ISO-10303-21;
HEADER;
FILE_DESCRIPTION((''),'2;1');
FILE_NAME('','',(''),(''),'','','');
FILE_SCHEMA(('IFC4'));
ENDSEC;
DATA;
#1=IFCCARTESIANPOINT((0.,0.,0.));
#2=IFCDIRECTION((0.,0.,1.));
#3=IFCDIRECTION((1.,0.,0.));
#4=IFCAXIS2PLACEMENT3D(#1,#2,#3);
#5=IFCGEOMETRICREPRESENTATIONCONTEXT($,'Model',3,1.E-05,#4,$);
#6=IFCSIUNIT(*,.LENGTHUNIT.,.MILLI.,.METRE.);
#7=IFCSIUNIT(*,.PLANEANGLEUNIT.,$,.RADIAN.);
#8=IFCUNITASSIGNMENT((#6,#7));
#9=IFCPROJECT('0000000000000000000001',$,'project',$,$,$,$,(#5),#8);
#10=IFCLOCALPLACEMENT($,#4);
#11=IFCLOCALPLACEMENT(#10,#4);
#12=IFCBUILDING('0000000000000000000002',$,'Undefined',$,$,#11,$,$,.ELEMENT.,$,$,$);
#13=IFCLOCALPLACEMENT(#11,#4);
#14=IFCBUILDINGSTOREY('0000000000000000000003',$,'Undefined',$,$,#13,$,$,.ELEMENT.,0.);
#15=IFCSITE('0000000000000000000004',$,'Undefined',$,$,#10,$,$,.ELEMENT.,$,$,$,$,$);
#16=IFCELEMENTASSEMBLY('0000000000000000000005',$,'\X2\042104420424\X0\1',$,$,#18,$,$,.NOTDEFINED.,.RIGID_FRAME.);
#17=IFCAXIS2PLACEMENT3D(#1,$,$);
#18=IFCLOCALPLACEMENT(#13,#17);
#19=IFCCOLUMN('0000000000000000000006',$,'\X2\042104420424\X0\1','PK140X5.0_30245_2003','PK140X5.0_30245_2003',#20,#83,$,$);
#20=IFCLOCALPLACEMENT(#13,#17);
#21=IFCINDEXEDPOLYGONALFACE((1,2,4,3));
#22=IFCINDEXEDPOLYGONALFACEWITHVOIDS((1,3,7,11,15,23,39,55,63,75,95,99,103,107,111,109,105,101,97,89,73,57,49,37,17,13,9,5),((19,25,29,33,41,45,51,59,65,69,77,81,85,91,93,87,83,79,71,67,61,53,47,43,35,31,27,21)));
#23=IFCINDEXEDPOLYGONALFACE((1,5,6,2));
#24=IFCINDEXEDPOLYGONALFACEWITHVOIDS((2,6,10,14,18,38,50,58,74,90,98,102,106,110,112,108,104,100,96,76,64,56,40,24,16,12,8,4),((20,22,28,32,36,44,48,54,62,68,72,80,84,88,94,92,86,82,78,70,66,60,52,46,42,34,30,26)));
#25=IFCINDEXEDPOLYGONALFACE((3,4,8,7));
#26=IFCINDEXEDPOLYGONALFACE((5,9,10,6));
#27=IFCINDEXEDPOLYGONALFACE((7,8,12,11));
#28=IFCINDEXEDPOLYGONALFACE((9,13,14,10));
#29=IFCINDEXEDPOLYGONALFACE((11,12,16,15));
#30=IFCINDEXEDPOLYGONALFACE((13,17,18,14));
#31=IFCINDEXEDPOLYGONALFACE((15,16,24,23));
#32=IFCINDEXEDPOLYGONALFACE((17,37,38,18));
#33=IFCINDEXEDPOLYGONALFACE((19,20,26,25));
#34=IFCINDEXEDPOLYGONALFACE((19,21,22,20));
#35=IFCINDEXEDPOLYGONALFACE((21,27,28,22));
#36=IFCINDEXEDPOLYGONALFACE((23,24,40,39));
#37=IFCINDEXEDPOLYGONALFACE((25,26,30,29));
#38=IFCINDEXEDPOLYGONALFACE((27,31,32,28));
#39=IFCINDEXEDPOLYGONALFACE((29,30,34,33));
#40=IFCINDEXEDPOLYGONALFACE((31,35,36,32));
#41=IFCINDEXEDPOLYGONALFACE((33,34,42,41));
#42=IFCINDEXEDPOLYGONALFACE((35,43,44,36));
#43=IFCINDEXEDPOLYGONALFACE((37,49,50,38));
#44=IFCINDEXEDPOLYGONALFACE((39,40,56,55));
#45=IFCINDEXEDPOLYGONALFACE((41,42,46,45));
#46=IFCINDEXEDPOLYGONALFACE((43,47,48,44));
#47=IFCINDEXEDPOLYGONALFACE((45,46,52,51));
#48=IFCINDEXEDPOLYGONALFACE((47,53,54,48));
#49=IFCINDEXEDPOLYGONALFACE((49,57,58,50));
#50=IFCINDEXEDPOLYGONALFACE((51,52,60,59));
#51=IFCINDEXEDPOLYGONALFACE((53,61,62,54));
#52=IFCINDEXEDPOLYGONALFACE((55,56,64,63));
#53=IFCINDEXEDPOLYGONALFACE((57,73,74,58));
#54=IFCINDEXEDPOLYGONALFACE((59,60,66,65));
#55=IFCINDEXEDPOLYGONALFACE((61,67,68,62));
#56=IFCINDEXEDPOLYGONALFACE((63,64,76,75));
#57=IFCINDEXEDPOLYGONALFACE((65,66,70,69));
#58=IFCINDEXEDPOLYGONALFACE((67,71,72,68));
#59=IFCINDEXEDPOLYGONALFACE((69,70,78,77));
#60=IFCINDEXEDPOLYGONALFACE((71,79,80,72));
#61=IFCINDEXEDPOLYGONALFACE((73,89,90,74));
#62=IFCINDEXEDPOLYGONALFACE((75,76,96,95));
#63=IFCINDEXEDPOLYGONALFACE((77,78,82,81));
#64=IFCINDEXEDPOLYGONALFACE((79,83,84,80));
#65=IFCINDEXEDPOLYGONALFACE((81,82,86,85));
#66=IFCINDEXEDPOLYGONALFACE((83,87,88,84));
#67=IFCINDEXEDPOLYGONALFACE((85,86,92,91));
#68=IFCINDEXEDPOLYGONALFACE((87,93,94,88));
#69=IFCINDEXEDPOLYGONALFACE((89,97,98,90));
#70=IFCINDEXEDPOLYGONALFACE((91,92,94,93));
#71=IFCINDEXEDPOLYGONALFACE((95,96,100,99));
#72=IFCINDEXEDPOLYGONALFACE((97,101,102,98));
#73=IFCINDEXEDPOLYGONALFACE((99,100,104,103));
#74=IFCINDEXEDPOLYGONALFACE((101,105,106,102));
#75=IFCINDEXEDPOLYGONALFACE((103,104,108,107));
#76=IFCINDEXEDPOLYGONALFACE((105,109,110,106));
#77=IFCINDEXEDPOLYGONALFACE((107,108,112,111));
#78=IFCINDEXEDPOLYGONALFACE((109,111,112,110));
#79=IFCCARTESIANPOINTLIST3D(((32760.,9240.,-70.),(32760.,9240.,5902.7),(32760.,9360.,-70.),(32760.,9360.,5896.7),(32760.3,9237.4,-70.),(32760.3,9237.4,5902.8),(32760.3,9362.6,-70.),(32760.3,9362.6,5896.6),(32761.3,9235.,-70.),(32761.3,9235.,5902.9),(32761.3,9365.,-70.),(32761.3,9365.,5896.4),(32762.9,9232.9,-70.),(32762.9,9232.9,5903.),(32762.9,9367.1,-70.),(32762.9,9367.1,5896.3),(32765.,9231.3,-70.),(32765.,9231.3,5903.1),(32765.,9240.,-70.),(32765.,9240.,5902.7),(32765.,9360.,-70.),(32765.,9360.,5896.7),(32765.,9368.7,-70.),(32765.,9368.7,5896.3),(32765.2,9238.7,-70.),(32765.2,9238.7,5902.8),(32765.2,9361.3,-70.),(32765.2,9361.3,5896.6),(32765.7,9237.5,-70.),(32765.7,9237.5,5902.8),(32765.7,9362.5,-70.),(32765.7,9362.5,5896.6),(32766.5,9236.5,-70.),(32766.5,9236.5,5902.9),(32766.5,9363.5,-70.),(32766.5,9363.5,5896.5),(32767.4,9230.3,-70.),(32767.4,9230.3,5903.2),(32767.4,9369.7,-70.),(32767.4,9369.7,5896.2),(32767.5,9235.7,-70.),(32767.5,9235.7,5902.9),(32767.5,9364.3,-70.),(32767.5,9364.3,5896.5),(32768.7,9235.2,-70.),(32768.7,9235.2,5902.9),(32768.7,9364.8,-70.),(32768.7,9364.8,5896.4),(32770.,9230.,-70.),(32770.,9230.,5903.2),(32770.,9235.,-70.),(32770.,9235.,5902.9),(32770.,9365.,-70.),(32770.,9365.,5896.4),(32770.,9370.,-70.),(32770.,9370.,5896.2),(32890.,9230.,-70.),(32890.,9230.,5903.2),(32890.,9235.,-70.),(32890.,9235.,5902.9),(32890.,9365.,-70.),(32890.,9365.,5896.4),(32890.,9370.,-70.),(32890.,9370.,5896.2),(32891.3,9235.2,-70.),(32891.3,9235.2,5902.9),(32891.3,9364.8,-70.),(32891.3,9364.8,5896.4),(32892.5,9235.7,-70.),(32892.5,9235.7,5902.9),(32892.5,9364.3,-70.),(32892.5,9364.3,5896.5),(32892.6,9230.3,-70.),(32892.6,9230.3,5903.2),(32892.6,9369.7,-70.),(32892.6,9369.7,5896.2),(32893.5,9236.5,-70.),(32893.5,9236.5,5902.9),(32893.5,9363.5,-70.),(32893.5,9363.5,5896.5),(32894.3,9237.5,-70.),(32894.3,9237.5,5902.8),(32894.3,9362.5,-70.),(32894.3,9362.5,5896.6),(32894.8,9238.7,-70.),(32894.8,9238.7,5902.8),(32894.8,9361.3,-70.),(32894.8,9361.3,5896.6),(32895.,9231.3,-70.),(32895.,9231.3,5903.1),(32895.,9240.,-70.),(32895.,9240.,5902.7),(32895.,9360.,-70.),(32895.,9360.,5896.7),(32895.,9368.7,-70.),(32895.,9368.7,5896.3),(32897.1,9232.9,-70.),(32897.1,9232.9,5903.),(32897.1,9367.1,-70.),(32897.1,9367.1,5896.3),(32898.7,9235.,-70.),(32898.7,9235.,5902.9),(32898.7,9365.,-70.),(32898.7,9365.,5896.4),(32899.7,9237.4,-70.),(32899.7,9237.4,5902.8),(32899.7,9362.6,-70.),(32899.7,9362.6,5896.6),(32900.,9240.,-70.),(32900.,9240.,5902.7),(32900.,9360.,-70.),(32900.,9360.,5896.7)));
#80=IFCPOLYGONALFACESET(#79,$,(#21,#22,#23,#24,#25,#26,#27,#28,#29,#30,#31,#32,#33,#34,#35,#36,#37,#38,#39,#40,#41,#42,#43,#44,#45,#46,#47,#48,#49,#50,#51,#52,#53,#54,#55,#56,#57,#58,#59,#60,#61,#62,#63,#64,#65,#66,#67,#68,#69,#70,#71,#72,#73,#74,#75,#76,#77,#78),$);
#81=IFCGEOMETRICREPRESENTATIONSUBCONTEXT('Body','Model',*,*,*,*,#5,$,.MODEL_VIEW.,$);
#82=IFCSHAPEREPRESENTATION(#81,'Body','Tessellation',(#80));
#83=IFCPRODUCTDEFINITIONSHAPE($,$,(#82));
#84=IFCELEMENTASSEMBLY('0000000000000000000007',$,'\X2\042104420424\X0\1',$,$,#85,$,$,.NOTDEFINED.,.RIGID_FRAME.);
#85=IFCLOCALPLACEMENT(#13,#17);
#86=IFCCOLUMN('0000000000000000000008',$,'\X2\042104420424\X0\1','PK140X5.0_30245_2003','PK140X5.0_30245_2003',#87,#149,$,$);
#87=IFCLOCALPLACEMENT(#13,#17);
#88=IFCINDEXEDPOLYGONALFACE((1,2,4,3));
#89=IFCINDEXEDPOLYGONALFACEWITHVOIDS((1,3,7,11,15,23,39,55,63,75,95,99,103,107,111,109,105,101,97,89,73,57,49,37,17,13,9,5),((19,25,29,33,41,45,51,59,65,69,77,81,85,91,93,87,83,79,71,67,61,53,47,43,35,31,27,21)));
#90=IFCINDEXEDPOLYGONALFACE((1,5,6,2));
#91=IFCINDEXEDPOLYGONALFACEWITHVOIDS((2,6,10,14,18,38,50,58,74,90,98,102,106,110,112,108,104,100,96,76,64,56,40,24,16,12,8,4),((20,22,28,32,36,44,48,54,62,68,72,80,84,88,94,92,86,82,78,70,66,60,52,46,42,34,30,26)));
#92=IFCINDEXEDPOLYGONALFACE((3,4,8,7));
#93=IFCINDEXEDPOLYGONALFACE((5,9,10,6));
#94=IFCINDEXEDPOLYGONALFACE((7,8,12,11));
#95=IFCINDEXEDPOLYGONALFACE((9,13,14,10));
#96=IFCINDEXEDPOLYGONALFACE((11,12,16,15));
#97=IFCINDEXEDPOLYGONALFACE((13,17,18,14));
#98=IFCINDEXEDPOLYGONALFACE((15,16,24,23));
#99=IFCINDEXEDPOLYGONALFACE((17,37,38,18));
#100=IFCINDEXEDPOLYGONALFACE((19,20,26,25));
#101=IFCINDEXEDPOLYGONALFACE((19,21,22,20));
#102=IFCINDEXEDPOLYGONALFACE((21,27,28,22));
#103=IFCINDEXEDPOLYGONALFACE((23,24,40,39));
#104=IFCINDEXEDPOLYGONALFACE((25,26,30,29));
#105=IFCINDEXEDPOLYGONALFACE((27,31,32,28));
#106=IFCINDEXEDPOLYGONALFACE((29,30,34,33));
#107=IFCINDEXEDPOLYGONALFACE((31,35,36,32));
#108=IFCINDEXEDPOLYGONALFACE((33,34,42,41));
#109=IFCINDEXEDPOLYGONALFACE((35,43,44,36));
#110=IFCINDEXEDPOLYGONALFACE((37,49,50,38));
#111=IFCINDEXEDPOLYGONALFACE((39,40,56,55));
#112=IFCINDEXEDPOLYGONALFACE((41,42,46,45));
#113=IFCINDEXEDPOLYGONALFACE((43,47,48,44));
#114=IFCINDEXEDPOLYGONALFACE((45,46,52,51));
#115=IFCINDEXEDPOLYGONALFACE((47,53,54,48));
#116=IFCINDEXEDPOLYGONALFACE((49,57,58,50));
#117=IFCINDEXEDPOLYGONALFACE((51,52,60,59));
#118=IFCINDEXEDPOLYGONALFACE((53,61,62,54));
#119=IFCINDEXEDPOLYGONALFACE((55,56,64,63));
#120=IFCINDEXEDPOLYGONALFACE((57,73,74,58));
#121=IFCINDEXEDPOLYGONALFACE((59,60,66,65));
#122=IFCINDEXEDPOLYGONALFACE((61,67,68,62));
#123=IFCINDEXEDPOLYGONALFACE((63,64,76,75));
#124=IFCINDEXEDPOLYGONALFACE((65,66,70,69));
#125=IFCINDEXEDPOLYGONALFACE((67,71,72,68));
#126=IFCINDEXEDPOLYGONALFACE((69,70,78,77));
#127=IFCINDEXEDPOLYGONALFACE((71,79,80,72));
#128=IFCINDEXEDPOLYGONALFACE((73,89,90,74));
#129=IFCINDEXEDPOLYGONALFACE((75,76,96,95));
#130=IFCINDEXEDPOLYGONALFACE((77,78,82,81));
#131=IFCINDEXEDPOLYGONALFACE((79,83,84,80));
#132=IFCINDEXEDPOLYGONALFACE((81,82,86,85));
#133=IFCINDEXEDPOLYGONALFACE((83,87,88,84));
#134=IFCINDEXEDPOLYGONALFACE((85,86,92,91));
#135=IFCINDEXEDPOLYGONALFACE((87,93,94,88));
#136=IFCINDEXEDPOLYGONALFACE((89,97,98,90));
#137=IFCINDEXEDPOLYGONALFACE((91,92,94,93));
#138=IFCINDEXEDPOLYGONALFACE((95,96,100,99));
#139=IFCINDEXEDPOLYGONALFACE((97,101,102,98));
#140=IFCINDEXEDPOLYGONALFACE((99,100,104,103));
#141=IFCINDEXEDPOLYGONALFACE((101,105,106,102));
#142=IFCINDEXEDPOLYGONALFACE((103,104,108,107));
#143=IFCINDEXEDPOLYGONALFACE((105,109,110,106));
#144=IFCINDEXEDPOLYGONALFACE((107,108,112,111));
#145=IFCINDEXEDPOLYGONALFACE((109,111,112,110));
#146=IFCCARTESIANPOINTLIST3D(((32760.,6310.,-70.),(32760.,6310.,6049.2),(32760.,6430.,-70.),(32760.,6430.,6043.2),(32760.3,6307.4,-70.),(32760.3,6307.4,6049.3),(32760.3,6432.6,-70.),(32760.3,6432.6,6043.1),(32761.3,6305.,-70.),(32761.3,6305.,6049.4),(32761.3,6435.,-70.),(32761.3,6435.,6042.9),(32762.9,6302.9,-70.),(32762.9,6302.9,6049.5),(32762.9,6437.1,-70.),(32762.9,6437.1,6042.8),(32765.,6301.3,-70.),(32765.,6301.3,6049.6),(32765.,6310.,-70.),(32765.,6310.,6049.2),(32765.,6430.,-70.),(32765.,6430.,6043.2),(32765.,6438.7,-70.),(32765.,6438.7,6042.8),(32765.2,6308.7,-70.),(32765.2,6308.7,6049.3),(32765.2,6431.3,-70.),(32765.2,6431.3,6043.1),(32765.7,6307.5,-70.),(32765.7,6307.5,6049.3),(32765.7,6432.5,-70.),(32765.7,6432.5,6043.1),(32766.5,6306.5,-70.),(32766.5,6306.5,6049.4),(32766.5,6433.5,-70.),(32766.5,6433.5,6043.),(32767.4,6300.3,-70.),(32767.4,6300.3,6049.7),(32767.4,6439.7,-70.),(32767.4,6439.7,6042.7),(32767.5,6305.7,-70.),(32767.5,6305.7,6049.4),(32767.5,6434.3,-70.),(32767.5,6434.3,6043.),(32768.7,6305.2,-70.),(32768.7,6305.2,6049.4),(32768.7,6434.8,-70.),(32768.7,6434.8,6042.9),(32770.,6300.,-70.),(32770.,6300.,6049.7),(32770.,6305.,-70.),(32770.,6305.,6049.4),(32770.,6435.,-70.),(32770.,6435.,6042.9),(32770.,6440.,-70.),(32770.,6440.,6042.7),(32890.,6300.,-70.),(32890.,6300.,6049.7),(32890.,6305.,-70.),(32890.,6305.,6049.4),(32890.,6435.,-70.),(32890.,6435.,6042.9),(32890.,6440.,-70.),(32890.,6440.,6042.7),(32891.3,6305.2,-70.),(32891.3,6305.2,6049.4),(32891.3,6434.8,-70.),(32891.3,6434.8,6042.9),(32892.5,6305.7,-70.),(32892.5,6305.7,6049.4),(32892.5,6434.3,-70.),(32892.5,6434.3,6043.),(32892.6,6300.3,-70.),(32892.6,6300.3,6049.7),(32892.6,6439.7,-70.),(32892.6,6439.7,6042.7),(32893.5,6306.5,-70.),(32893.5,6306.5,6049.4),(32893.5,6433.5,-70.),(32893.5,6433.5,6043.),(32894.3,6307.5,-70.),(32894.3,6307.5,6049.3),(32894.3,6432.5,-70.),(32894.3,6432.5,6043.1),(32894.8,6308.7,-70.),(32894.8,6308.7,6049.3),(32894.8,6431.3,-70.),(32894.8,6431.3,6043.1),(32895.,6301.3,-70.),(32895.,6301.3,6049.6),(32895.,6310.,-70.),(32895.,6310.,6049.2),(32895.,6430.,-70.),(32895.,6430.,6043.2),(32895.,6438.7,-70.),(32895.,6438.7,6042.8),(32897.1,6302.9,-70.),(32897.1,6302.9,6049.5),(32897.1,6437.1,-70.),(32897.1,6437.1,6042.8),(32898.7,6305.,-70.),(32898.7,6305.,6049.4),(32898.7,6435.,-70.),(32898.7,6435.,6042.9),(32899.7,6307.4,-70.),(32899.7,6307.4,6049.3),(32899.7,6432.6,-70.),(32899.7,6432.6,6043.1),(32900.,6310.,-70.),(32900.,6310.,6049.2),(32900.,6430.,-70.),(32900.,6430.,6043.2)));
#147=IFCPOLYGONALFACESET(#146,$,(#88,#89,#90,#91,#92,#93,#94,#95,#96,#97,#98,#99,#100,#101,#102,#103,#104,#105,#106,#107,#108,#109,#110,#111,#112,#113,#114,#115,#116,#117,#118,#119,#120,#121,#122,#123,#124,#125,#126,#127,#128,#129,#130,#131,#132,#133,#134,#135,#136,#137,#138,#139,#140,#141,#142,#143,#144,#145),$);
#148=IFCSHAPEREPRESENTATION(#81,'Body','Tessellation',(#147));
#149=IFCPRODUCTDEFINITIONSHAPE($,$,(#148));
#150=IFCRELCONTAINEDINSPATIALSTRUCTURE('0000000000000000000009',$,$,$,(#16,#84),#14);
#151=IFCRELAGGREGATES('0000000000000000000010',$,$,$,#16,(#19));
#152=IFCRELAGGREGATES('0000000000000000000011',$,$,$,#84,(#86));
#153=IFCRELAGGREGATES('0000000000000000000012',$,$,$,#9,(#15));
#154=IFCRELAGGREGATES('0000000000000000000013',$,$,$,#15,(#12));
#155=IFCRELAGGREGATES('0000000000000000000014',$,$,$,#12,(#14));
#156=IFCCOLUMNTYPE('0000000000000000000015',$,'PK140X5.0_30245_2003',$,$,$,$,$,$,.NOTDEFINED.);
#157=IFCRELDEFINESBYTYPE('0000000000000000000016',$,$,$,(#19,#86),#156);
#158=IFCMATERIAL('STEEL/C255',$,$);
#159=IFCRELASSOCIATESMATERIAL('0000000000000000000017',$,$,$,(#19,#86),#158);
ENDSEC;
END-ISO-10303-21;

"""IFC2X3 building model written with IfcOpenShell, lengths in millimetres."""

from ifc_helpers import new_model, si_unit, frame, origin_with_axes, origin_2d_with_axis, place, context, subcontext, project, spatial, hollow_rectangle, extrude, clip, halfspace, material, type_object, element, aggregate, save


model = new_model("IFC2X3")

# Units and contexts
model_context = context("Model", 3, precision=1e-05, world=origin_with_axes())
body_context = subcontext(model_context, "Body", "Model", "MODEL_VIEW")
ifc_project = project(units=[si_unit("LENGTHUNIT", "METRE", prefix="MILLI"), si_unit("PLANEANGLEUNIT", "RADIAN")], contexts=[model_context])

# Site, building, storey
site_placement = place(None, origin_with_axes())
site = spatial("IfcSite", under=ifc_project, at=site_placement, Name="Undefined", CompositionType="ELEMENT")
building_placement = place(site_placement, origin_with_axes())
building = spatial("IfcBuilding", under=site, at=building_placement, Name="Undefined", CompositionType="ELEMENT")
storey_placement = place(building_placement, origin_with_axes())
storey = spatial("IfcBuildingStorey", under=building, at=storey_placement, Name="Undefined", CompositionType="ELEMENT", Elevation=0.0)

# Element assemblies, columns
assembly_1_placement = place(storey_placement, origin_with_axes())
assembly_1 = element("IfcElementAssembly", 1, at=assembly_1_placement, inside=storey, Name="СтФ1", AssemblyPlace="NOTDEFINED", PredefinedType="RIGID_FRAME")
ifc_material_1 = material(Name="STEEL/C255")
column_type_1 = type_object("IfcColumnType", Name="PK140X5.0_30245_2003", PredefinedType="NOTDEFINED")
column_1_placement = place(assembly_1_placement, frame((32830.0, 9300.0, -70.0), z_axis=(0.0, 0.0, 1.0), x_axis=(0.0, 1.0, 0.0)))
column_1 = element("IfcColumn", 2, at=column_1_placement, type_object=column_type_1, material=ifc_material_1, Name="СтФ1", Description="PK140X5.0_30245_2003", ObjectType="PK140X5.0_30245_2003", context=body_context, shape_type="Clipping", body=[
    clip(extrude(hollow_rectangle(XDim=140.0, YDim=140.0, WallThickness=5.0, InnerFilletRadius=5.0, OuterFilletRadius=10.0, at=origin_2d_with_axis()), frame((0.0, 0.0, 6020.0), z_axis=(0.0, 0.0, -1.0), x_axis=(0.0, 1.0, 0.0)), (0.0, 0.0, 1.0), 6020.0), halfspace(frame((-70.0, 70.0, 5973.2), z_axis=(0.049938, 0.0, 0.998752), x_axis=(0.998752, 0.0, -0.049938)), False)),
])
aggregate(assembly_1, [column_1])
assembly_2_placement = place(storey_placement, origin_with_axes())
assembly_2 = element("IfcElementAssembly", 3, at=assembly_2_placement, inside=storey, Name="СтФ1", AssemblyPlace="NOTDEFINED", PredefinedType="RIGID_FRAME")
column_2_placement = place(assembly_2_placement, frame((32830.0, 6370.0, -70.0), z_axis=(0.0, 0.0, 1.0), x_axis=(-1.0, 0.0, 0.0)))
column_2 = element("IfcColumn", 4, at=column_2_placement, type_object=column_type_1, material=ifc_material_1, Name="СтФ1", Description="PK140X5.0_30245_2003", ObjectType="PK140X5.0_30245_2003", context=body_context, shape_type="Clipping", body=[
    clip(extrude(hollow_rectangle(XDim=140.0, YDim=140.0, WallThickness=5.0, InnerFilletRadius=5.0, OuterFilletRadius=10.0, at=origin_2d_with_axis()), frame((0.0, 0.0, 6120.0), z_axis=(0.0, 0.0, -1.0), x_axis=(0.0, 1.0, 0.0)), (0.0, 0.0, 1.0), 6120.0), halfspace(frame((-70.0, 70.0, 6119.7), z_axis=(0.0, -0.049938, 0.998752), x_axis=(1.0, 0.0, 0.0)), False)),
])
aggregate(assembly_2, [column_2])

save(model, "model.ifc")
